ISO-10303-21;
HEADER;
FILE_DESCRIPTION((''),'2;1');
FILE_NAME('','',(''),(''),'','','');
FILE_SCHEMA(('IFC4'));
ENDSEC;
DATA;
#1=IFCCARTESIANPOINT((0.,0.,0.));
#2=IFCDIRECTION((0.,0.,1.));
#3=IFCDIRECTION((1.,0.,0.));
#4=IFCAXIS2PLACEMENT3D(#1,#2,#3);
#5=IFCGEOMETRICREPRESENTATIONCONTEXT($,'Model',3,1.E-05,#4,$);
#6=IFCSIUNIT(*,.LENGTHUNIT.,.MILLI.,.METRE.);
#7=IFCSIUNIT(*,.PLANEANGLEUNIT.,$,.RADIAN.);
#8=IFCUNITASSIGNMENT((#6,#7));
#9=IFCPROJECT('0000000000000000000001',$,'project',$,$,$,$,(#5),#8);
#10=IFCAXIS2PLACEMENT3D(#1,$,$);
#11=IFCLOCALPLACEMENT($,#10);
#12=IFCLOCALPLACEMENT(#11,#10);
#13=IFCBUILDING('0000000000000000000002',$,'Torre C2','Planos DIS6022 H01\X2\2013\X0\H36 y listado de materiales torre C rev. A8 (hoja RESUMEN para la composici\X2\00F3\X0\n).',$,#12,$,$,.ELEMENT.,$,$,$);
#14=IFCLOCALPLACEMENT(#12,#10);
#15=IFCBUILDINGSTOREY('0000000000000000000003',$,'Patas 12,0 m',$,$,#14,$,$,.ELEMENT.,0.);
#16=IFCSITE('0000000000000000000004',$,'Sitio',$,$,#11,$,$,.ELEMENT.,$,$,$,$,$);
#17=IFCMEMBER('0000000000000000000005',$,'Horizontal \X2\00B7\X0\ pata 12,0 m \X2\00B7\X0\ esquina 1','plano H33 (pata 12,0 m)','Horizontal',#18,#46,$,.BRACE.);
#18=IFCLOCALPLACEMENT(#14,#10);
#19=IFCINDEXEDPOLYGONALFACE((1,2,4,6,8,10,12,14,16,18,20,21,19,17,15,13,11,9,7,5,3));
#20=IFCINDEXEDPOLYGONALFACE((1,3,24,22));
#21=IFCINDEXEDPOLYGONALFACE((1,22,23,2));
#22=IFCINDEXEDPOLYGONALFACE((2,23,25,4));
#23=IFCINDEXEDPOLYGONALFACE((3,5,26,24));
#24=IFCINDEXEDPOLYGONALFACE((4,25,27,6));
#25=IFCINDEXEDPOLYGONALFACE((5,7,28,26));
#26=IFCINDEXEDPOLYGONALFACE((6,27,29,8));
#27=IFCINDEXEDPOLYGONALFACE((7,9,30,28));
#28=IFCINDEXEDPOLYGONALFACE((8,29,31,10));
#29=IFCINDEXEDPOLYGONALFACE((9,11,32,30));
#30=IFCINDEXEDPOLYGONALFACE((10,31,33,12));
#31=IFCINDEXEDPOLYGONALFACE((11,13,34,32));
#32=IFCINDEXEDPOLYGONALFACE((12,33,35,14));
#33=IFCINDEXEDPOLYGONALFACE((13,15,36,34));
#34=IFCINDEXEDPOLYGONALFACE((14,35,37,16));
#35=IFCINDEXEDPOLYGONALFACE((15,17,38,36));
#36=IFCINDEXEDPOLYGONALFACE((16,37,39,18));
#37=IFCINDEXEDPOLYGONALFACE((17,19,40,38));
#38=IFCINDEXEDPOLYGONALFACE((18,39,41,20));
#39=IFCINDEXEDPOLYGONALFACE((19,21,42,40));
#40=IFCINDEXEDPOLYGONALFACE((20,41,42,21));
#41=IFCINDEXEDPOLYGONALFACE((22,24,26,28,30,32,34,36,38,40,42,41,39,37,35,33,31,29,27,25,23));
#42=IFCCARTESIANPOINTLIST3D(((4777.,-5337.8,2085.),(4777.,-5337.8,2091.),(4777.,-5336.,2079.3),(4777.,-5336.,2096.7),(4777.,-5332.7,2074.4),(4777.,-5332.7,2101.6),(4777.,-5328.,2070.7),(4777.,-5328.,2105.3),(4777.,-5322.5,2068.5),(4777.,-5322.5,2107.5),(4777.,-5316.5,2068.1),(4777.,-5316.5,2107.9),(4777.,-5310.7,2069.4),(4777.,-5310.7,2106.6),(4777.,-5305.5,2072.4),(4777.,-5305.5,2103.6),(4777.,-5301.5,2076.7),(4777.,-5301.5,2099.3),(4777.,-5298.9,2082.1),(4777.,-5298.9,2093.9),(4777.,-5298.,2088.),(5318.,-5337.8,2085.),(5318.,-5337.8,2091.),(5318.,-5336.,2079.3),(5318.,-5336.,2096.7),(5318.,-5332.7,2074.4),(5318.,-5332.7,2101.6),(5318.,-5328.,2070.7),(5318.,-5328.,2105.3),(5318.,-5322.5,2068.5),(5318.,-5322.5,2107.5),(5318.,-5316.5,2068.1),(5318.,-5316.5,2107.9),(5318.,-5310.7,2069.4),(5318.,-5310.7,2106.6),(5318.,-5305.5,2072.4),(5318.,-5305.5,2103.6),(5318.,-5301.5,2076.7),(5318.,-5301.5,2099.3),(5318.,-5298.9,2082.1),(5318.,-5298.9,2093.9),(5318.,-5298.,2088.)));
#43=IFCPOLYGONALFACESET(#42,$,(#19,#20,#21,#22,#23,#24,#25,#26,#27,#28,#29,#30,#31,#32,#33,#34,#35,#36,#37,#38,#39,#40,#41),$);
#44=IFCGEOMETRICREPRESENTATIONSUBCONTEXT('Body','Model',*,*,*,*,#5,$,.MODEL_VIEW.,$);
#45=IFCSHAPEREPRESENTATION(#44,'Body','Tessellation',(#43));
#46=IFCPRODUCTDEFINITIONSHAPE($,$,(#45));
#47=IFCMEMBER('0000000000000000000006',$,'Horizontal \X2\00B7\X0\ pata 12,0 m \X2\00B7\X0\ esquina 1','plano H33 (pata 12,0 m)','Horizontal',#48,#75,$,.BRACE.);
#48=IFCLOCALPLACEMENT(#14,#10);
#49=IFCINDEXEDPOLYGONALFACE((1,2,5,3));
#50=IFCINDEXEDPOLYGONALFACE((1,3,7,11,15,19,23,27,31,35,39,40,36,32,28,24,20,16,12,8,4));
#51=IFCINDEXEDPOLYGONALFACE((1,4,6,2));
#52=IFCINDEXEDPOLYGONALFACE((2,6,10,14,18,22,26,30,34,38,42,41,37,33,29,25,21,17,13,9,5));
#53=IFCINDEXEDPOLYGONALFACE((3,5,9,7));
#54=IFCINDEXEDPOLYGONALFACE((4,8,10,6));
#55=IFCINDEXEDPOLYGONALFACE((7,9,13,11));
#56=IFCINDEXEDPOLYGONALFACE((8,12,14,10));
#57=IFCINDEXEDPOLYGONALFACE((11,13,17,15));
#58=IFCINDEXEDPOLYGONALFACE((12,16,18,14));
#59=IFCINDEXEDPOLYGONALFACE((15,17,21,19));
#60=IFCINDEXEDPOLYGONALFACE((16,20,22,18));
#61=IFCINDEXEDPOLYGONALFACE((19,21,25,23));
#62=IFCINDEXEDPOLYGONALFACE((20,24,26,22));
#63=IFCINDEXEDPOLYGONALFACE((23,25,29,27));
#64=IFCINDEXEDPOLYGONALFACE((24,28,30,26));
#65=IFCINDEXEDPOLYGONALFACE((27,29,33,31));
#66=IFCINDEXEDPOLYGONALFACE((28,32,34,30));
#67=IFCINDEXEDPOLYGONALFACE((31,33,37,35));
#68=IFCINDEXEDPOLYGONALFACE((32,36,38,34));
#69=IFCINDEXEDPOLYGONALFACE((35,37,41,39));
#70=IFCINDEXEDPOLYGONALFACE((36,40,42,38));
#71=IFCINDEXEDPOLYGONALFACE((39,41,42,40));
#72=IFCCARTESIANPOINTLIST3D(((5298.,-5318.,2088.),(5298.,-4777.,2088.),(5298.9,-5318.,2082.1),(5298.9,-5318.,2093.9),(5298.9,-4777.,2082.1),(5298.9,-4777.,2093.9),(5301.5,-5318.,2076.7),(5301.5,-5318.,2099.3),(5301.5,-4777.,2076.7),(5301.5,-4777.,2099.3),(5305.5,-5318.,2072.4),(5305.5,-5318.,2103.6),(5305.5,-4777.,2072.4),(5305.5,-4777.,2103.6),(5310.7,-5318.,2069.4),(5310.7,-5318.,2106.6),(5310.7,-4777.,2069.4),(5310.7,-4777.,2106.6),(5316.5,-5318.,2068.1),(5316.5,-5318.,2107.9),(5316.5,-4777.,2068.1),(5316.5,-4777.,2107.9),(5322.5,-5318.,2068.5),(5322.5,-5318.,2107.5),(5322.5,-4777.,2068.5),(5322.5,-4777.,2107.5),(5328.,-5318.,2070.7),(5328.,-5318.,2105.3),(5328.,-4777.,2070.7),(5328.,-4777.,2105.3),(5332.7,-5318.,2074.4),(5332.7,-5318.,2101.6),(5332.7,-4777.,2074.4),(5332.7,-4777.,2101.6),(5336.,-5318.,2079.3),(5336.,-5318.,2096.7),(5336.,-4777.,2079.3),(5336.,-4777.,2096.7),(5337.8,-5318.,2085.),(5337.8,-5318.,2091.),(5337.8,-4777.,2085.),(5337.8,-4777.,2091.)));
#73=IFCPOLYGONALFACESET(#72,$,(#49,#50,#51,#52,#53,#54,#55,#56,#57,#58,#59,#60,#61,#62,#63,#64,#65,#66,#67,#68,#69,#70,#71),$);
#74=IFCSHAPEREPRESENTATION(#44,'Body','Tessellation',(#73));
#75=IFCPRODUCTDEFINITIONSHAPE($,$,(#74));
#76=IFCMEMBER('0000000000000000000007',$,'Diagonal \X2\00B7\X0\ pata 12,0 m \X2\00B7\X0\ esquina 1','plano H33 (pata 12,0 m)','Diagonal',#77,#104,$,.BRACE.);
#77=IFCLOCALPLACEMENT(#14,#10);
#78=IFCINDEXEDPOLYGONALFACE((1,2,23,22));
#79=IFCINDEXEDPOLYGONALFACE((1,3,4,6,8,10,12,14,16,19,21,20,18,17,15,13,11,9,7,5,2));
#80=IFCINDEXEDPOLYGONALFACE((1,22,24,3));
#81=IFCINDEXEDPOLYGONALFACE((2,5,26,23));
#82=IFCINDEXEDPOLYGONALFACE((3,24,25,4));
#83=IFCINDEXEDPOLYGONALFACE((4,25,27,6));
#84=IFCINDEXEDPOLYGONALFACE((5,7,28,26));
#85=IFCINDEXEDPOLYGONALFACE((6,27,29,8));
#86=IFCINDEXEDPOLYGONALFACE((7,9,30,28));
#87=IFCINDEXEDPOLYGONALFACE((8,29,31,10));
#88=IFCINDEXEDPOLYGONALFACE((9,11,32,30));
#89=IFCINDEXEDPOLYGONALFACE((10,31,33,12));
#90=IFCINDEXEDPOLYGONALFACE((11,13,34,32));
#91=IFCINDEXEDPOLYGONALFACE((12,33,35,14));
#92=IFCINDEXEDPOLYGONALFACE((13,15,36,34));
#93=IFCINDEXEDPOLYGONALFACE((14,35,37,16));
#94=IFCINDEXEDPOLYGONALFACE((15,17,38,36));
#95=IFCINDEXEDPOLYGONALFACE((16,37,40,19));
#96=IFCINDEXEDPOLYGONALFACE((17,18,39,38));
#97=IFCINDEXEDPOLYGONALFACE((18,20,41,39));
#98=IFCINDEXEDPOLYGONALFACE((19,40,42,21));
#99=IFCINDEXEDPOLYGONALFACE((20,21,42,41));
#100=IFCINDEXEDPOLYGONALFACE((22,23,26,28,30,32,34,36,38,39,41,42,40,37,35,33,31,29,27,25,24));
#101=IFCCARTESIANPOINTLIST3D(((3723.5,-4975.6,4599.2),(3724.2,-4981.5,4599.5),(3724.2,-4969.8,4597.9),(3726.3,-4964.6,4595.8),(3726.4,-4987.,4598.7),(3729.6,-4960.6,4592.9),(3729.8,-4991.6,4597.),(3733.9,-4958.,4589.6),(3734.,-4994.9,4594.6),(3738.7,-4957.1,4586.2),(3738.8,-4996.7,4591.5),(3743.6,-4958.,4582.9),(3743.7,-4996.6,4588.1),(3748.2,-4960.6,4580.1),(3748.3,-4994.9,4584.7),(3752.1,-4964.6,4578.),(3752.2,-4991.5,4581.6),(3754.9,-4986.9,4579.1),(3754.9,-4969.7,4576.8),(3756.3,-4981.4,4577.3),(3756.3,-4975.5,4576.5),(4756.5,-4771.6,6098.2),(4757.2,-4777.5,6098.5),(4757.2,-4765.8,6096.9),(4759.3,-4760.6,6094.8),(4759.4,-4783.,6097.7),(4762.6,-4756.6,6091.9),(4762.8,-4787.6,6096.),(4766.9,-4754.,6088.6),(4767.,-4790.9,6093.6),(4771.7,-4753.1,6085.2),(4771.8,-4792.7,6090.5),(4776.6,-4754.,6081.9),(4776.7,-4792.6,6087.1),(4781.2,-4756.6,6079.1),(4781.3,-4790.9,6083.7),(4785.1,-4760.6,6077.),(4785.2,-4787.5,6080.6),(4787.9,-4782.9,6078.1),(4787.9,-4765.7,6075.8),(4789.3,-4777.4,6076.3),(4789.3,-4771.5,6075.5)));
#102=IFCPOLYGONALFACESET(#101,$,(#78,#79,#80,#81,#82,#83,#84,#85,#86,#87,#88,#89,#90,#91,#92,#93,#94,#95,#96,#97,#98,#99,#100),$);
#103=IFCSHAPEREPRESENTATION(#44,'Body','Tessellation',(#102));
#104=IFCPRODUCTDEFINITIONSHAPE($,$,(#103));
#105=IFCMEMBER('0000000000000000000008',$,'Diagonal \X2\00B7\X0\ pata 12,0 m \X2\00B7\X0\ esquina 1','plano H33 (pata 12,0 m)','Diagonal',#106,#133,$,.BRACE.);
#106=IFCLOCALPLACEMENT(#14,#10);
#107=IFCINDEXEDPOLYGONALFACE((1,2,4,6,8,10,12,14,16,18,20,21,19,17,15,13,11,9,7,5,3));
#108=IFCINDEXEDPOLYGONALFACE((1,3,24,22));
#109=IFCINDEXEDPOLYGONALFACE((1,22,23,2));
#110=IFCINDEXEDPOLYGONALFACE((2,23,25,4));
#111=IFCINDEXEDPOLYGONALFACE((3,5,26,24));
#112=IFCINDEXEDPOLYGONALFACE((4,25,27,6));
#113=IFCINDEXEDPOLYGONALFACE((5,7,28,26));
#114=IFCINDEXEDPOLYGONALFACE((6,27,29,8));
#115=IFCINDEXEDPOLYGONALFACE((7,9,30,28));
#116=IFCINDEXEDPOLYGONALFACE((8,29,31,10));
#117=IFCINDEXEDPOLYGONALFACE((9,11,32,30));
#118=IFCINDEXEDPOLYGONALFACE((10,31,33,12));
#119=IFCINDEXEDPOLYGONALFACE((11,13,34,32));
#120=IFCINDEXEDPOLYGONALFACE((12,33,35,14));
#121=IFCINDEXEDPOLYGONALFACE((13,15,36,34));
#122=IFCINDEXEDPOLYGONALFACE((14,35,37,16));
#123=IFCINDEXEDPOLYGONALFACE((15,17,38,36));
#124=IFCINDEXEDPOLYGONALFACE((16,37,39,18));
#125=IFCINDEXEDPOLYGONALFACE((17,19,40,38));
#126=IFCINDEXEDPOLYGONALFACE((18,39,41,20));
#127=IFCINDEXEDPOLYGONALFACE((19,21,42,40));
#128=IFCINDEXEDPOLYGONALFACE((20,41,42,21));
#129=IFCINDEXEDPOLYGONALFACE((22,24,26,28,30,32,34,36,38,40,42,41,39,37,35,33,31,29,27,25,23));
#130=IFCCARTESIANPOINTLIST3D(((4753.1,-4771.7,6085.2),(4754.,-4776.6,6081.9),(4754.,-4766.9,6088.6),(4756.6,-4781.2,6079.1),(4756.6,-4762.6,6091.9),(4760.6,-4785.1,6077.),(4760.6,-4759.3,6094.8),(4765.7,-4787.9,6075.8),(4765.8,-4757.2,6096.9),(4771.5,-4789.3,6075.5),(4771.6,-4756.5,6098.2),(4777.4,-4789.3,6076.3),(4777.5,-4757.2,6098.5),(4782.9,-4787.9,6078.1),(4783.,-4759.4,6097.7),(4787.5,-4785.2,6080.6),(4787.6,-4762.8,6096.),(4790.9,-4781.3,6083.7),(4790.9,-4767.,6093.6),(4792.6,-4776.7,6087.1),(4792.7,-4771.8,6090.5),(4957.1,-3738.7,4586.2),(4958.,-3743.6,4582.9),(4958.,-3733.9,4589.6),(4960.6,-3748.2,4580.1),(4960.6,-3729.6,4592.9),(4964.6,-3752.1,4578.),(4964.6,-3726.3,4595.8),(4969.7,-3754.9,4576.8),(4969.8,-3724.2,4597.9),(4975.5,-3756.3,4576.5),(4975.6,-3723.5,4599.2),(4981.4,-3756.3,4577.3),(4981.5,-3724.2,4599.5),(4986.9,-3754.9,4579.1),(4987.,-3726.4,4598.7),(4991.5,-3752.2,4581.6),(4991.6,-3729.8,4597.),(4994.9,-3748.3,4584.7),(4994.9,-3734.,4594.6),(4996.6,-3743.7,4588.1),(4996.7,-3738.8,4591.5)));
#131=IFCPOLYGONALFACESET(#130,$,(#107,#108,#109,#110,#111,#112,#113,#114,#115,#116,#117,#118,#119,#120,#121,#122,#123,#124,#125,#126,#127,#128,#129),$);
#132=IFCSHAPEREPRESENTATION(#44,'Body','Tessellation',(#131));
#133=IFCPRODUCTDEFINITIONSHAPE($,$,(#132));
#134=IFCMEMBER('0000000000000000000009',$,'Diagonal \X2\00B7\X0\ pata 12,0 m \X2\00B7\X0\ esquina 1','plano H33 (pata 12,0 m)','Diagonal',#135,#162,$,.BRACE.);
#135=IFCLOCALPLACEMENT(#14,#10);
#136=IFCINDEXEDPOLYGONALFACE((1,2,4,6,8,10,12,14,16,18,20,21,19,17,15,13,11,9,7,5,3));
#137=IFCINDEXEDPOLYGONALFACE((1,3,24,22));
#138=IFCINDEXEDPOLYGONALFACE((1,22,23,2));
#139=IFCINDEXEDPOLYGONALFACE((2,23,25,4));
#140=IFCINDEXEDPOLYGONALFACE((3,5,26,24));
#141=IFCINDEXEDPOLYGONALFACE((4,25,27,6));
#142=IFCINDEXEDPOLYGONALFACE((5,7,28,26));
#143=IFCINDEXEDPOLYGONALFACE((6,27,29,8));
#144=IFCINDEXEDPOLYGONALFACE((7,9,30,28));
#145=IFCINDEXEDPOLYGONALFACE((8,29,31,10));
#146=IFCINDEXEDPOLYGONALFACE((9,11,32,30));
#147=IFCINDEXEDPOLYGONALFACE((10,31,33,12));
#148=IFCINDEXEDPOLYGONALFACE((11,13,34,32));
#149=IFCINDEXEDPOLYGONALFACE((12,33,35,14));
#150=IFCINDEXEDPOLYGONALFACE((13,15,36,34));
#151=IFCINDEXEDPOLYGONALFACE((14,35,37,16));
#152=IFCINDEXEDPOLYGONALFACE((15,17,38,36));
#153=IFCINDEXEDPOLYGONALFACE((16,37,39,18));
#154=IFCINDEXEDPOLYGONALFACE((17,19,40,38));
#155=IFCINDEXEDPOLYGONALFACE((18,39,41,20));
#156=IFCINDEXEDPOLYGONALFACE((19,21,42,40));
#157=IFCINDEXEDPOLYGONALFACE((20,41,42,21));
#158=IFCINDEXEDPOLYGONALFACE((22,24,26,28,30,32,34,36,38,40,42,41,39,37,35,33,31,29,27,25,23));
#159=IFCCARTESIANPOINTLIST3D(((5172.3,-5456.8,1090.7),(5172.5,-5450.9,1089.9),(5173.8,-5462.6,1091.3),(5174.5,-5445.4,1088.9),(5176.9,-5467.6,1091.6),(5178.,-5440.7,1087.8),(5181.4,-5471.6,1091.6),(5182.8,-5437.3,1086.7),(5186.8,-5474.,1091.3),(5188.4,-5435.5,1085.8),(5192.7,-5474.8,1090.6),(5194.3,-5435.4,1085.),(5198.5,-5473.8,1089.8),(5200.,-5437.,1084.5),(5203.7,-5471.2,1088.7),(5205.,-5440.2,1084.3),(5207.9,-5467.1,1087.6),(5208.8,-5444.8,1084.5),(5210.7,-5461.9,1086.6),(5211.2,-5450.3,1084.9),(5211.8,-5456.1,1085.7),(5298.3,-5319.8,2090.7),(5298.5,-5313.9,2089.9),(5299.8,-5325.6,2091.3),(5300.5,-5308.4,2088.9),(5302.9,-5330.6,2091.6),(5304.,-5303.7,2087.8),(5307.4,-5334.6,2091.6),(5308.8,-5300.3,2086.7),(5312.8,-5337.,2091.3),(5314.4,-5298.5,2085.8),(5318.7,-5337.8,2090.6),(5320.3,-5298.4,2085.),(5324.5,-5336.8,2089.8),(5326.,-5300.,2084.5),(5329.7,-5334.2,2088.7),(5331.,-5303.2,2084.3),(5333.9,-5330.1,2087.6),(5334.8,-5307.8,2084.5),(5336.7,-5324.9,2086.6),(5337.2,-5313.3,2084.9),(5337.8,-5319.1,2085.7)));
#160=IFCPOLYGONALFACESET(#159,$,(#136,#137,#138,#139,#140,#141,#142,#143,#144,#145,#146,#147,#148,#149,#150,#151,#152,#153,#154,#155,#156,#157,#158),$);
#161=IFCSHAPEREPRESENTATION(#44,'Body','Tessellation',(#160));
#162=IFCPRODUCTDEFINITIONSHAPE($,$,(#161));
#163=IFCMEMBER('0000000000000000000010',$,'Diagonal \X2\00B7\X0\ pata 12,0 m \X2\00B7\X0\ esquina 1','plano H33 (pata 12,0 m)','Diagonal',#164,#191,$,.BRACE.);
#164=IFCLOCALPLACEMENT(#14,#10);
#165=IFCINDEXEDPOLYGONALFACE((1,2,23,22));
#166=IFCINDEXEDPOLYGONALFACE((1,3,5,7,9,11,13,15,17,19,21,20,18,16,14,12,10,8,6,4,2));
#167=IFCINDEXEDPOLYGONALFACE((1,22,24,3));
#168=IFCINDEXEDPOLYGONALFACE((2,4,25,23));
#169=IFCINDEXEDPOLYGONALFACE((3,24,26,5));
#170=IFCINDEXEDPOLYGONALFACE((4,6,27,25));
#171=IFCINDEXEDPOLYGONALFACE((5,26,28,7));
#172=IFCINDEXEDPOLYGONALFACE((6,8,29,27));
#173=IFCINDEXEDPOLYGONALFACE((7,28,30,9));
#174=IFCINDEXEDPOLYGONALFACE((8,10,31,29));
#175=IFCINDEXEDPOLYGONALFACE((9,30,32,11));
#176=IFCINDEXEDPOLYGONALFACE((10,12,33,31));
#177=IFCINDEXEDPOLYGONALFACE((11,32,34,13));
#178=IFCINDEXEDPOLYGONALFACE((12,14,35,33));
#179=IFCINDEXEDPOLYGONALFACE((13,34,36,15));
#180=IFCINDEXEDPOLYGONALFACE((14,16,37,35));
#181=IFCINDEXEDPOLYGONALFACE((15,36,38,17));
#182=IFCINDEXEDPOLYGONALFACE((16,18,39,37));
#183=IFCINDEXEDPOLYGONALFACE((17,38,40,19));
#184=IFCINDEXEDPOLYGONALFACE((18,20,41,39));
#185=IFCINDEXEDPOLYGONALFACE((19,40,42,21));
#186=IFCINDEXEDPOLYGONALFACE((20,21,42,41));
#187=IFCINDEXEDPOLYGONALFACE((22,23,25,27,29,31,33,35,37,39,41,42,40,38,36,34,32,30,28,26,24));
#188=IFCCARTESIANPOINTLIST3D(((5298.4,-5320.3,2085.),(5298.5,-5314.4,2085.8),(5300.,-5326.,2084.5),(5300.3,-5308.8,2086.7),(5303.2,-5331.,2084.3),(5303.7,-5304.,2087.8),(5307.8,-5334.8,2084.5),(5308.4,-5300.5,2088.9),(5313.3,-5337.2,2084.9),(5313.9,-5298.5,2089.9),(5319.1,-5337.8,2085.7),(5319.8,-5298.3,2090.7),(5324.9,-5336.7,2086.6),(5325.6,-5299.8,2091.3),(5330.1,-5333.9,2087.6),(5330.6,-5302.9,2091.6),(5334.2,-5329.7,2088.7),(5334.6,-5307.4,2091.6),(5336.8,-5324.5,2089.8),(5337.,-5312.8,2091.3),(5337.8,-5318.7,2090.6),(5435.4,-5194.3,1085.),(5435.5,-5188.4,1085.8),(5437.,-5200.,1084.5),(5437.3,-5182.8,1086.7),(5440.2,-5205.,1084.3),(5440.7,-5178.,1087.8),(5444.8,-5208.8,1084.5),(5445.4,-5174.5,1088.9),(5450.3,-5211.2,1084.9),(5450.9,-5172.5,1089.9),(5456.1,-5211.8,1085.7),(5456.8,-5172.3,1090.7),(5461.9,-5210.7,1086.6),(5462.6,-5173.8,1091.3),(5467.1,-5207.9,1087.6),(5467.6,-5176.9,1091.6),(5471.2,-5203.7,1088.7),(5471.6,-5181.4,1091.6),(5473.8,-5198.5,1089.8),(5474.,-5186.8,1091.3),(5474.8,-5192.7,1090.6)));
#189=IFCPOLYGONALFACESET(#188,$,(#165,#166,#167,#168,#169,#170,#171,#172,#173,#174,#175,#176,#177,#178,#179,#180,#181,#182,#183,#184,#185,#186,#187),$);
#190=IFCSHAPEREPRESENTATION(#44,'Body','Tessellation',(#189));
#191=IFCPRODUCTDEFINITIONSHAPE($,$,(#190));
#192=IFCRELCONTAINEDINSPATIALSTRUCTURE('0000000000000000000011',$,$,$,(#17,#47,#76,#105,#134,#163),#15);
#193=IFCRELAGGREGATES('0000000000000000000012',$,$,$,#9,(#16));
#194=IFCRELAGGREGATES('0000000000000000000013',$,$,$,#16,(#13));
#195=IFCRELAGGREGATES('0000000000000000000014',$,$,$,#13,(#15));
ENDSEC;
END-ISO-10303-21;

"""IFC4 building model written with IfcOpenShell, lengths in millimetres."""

from ifc_helpers import new_model, si_unit, frame, origin, origin_with_axes, place, context, subcontext, project, spatial, circle, extrude, element, save


model = new_model("IFC4")

# Units and contexts
model_context = context("Model", 3, precision=1e-05, world=origin_with_axes())
body_context = subcontext(model_context, "Body", "Model", "MODEL_VIEW")
ifc_project = project(units=[si_unit("LENGTHUNIT", "METRE", prefix="MILLI"), si_unit("PLANEANGLEUNIT", "RADIAN")], contexts=[model_context])

# Site, building, storey
site_placement = place(None, origin())
site = spatial("IfcSite", under=ifc_project, at=site_placement, Name="Sitio", CompositionType="ELEMENT")
building_placement = place(site_placement, origin())
building = spatial("IfcBuilding", under=site, at=building_placement, Name="Torre C2", Description="Planos DIS6022 H01–H36 y listado de materiales torre C rev. A8 (hoja RESUMEN para la composición).", CompositionType="ELEMENT")
storey_placement = place(building_placement, origin())
storey = spatial("IfcBuildingStorey", under=building, at=storey_placement, Name="Patas 12,0 m", CompositionType="ELEMENT", Elevation=0.0)

# Members
for number, where, z_axis, x_axis, name in (
    (1, (4777.0, -5318.0, 2088.0), (1.0, 0.0, 0.0), (0.0, 1.0, 0.0), "Horizontal · pata 12,0 m · esquina 1"),
    (2, (5318.0, -4777.0, 2088.0), (0.0, -1.0, 0.0), (-1.0, 0.0, 0.0), "Horizontal · pata 12,0 m · esquina 1"),
):
    element("IfcMember", number, at=place(storey_placement, frame(where, z_axis=z_axis, x_axis=x_axis)), inside=storey, Name=name, Description="plano H33 (pata 12,0 m)", ObjectType="Horizontal", PredefinedType="BRACE", context=body_context, shape_type="SweptSolid", body=[
        extrude(circle(Radius=20.0), None, (0.0, 0.0, 1.0), 541.0),
    ])
for number, where, z_axis, x_axis, name in (
    (3, (4773.0, -4773.0, 6087.0), (-0.563908, -0.111362, -0.818295), (-0.517641, 0.819721, 0.245164), "Diagonal · pata 12,0 m · esquina 1"),
    (4, (4773.0, -4773.0, 6087.0), (0.111362, 0.563908, -0.818295), (-0.819721, 0.517641, 0.245164), "Diagonal · pata 12,0 m · esquina 1"),
):
    element("IfcMember", number, at=place(storey_placement, frame(where, z_axis=z_axis, x_axis=x_axis)), inside=storey, Name=name, Description="plano H33 (pata 12,0 m)", ObjectType="Diagonal", PredefinedType="BRACE", context=body_context, shape_type="SweptSolid", body=[
        extrude(circle(Radius=20.0), None, (0.0, 0.0, 1.0), 1831.9),
    ])
for number, where, z_axis, x_axis, name in (
    (5, (5318.0, -5318.0, 2088.0), (-0.123872, -0.134687, -0.983115), (-0.699577, 0.714491, -0.009739), "Diagonal · pata 12,0 m · esquina 1"),
    (6, (5318.0, -5318.0, 2088.0), (0.134687, 0.123872, -0.983115), (-0.714491, 0.699577, -0.009739), "Diagonal · pata 12,0 m · esquina 1"),
):
    element("IfcMember", number, at=place(storey_placement, frame(where, z_axis=z_axis, x_axis=x_axis)), inside=storey, Name=name, Description="plano H33 (pata 12,0 m)", ObjectType="Diagonal", PredefinedType="BRACE", context=body_context, shape_type="SweptSolid", body=[
        extrude(circle(Radius=20.0), None, (0.0, 0.0, 1.0), 1017.2),
    ])

save(model, "model.ifc")
